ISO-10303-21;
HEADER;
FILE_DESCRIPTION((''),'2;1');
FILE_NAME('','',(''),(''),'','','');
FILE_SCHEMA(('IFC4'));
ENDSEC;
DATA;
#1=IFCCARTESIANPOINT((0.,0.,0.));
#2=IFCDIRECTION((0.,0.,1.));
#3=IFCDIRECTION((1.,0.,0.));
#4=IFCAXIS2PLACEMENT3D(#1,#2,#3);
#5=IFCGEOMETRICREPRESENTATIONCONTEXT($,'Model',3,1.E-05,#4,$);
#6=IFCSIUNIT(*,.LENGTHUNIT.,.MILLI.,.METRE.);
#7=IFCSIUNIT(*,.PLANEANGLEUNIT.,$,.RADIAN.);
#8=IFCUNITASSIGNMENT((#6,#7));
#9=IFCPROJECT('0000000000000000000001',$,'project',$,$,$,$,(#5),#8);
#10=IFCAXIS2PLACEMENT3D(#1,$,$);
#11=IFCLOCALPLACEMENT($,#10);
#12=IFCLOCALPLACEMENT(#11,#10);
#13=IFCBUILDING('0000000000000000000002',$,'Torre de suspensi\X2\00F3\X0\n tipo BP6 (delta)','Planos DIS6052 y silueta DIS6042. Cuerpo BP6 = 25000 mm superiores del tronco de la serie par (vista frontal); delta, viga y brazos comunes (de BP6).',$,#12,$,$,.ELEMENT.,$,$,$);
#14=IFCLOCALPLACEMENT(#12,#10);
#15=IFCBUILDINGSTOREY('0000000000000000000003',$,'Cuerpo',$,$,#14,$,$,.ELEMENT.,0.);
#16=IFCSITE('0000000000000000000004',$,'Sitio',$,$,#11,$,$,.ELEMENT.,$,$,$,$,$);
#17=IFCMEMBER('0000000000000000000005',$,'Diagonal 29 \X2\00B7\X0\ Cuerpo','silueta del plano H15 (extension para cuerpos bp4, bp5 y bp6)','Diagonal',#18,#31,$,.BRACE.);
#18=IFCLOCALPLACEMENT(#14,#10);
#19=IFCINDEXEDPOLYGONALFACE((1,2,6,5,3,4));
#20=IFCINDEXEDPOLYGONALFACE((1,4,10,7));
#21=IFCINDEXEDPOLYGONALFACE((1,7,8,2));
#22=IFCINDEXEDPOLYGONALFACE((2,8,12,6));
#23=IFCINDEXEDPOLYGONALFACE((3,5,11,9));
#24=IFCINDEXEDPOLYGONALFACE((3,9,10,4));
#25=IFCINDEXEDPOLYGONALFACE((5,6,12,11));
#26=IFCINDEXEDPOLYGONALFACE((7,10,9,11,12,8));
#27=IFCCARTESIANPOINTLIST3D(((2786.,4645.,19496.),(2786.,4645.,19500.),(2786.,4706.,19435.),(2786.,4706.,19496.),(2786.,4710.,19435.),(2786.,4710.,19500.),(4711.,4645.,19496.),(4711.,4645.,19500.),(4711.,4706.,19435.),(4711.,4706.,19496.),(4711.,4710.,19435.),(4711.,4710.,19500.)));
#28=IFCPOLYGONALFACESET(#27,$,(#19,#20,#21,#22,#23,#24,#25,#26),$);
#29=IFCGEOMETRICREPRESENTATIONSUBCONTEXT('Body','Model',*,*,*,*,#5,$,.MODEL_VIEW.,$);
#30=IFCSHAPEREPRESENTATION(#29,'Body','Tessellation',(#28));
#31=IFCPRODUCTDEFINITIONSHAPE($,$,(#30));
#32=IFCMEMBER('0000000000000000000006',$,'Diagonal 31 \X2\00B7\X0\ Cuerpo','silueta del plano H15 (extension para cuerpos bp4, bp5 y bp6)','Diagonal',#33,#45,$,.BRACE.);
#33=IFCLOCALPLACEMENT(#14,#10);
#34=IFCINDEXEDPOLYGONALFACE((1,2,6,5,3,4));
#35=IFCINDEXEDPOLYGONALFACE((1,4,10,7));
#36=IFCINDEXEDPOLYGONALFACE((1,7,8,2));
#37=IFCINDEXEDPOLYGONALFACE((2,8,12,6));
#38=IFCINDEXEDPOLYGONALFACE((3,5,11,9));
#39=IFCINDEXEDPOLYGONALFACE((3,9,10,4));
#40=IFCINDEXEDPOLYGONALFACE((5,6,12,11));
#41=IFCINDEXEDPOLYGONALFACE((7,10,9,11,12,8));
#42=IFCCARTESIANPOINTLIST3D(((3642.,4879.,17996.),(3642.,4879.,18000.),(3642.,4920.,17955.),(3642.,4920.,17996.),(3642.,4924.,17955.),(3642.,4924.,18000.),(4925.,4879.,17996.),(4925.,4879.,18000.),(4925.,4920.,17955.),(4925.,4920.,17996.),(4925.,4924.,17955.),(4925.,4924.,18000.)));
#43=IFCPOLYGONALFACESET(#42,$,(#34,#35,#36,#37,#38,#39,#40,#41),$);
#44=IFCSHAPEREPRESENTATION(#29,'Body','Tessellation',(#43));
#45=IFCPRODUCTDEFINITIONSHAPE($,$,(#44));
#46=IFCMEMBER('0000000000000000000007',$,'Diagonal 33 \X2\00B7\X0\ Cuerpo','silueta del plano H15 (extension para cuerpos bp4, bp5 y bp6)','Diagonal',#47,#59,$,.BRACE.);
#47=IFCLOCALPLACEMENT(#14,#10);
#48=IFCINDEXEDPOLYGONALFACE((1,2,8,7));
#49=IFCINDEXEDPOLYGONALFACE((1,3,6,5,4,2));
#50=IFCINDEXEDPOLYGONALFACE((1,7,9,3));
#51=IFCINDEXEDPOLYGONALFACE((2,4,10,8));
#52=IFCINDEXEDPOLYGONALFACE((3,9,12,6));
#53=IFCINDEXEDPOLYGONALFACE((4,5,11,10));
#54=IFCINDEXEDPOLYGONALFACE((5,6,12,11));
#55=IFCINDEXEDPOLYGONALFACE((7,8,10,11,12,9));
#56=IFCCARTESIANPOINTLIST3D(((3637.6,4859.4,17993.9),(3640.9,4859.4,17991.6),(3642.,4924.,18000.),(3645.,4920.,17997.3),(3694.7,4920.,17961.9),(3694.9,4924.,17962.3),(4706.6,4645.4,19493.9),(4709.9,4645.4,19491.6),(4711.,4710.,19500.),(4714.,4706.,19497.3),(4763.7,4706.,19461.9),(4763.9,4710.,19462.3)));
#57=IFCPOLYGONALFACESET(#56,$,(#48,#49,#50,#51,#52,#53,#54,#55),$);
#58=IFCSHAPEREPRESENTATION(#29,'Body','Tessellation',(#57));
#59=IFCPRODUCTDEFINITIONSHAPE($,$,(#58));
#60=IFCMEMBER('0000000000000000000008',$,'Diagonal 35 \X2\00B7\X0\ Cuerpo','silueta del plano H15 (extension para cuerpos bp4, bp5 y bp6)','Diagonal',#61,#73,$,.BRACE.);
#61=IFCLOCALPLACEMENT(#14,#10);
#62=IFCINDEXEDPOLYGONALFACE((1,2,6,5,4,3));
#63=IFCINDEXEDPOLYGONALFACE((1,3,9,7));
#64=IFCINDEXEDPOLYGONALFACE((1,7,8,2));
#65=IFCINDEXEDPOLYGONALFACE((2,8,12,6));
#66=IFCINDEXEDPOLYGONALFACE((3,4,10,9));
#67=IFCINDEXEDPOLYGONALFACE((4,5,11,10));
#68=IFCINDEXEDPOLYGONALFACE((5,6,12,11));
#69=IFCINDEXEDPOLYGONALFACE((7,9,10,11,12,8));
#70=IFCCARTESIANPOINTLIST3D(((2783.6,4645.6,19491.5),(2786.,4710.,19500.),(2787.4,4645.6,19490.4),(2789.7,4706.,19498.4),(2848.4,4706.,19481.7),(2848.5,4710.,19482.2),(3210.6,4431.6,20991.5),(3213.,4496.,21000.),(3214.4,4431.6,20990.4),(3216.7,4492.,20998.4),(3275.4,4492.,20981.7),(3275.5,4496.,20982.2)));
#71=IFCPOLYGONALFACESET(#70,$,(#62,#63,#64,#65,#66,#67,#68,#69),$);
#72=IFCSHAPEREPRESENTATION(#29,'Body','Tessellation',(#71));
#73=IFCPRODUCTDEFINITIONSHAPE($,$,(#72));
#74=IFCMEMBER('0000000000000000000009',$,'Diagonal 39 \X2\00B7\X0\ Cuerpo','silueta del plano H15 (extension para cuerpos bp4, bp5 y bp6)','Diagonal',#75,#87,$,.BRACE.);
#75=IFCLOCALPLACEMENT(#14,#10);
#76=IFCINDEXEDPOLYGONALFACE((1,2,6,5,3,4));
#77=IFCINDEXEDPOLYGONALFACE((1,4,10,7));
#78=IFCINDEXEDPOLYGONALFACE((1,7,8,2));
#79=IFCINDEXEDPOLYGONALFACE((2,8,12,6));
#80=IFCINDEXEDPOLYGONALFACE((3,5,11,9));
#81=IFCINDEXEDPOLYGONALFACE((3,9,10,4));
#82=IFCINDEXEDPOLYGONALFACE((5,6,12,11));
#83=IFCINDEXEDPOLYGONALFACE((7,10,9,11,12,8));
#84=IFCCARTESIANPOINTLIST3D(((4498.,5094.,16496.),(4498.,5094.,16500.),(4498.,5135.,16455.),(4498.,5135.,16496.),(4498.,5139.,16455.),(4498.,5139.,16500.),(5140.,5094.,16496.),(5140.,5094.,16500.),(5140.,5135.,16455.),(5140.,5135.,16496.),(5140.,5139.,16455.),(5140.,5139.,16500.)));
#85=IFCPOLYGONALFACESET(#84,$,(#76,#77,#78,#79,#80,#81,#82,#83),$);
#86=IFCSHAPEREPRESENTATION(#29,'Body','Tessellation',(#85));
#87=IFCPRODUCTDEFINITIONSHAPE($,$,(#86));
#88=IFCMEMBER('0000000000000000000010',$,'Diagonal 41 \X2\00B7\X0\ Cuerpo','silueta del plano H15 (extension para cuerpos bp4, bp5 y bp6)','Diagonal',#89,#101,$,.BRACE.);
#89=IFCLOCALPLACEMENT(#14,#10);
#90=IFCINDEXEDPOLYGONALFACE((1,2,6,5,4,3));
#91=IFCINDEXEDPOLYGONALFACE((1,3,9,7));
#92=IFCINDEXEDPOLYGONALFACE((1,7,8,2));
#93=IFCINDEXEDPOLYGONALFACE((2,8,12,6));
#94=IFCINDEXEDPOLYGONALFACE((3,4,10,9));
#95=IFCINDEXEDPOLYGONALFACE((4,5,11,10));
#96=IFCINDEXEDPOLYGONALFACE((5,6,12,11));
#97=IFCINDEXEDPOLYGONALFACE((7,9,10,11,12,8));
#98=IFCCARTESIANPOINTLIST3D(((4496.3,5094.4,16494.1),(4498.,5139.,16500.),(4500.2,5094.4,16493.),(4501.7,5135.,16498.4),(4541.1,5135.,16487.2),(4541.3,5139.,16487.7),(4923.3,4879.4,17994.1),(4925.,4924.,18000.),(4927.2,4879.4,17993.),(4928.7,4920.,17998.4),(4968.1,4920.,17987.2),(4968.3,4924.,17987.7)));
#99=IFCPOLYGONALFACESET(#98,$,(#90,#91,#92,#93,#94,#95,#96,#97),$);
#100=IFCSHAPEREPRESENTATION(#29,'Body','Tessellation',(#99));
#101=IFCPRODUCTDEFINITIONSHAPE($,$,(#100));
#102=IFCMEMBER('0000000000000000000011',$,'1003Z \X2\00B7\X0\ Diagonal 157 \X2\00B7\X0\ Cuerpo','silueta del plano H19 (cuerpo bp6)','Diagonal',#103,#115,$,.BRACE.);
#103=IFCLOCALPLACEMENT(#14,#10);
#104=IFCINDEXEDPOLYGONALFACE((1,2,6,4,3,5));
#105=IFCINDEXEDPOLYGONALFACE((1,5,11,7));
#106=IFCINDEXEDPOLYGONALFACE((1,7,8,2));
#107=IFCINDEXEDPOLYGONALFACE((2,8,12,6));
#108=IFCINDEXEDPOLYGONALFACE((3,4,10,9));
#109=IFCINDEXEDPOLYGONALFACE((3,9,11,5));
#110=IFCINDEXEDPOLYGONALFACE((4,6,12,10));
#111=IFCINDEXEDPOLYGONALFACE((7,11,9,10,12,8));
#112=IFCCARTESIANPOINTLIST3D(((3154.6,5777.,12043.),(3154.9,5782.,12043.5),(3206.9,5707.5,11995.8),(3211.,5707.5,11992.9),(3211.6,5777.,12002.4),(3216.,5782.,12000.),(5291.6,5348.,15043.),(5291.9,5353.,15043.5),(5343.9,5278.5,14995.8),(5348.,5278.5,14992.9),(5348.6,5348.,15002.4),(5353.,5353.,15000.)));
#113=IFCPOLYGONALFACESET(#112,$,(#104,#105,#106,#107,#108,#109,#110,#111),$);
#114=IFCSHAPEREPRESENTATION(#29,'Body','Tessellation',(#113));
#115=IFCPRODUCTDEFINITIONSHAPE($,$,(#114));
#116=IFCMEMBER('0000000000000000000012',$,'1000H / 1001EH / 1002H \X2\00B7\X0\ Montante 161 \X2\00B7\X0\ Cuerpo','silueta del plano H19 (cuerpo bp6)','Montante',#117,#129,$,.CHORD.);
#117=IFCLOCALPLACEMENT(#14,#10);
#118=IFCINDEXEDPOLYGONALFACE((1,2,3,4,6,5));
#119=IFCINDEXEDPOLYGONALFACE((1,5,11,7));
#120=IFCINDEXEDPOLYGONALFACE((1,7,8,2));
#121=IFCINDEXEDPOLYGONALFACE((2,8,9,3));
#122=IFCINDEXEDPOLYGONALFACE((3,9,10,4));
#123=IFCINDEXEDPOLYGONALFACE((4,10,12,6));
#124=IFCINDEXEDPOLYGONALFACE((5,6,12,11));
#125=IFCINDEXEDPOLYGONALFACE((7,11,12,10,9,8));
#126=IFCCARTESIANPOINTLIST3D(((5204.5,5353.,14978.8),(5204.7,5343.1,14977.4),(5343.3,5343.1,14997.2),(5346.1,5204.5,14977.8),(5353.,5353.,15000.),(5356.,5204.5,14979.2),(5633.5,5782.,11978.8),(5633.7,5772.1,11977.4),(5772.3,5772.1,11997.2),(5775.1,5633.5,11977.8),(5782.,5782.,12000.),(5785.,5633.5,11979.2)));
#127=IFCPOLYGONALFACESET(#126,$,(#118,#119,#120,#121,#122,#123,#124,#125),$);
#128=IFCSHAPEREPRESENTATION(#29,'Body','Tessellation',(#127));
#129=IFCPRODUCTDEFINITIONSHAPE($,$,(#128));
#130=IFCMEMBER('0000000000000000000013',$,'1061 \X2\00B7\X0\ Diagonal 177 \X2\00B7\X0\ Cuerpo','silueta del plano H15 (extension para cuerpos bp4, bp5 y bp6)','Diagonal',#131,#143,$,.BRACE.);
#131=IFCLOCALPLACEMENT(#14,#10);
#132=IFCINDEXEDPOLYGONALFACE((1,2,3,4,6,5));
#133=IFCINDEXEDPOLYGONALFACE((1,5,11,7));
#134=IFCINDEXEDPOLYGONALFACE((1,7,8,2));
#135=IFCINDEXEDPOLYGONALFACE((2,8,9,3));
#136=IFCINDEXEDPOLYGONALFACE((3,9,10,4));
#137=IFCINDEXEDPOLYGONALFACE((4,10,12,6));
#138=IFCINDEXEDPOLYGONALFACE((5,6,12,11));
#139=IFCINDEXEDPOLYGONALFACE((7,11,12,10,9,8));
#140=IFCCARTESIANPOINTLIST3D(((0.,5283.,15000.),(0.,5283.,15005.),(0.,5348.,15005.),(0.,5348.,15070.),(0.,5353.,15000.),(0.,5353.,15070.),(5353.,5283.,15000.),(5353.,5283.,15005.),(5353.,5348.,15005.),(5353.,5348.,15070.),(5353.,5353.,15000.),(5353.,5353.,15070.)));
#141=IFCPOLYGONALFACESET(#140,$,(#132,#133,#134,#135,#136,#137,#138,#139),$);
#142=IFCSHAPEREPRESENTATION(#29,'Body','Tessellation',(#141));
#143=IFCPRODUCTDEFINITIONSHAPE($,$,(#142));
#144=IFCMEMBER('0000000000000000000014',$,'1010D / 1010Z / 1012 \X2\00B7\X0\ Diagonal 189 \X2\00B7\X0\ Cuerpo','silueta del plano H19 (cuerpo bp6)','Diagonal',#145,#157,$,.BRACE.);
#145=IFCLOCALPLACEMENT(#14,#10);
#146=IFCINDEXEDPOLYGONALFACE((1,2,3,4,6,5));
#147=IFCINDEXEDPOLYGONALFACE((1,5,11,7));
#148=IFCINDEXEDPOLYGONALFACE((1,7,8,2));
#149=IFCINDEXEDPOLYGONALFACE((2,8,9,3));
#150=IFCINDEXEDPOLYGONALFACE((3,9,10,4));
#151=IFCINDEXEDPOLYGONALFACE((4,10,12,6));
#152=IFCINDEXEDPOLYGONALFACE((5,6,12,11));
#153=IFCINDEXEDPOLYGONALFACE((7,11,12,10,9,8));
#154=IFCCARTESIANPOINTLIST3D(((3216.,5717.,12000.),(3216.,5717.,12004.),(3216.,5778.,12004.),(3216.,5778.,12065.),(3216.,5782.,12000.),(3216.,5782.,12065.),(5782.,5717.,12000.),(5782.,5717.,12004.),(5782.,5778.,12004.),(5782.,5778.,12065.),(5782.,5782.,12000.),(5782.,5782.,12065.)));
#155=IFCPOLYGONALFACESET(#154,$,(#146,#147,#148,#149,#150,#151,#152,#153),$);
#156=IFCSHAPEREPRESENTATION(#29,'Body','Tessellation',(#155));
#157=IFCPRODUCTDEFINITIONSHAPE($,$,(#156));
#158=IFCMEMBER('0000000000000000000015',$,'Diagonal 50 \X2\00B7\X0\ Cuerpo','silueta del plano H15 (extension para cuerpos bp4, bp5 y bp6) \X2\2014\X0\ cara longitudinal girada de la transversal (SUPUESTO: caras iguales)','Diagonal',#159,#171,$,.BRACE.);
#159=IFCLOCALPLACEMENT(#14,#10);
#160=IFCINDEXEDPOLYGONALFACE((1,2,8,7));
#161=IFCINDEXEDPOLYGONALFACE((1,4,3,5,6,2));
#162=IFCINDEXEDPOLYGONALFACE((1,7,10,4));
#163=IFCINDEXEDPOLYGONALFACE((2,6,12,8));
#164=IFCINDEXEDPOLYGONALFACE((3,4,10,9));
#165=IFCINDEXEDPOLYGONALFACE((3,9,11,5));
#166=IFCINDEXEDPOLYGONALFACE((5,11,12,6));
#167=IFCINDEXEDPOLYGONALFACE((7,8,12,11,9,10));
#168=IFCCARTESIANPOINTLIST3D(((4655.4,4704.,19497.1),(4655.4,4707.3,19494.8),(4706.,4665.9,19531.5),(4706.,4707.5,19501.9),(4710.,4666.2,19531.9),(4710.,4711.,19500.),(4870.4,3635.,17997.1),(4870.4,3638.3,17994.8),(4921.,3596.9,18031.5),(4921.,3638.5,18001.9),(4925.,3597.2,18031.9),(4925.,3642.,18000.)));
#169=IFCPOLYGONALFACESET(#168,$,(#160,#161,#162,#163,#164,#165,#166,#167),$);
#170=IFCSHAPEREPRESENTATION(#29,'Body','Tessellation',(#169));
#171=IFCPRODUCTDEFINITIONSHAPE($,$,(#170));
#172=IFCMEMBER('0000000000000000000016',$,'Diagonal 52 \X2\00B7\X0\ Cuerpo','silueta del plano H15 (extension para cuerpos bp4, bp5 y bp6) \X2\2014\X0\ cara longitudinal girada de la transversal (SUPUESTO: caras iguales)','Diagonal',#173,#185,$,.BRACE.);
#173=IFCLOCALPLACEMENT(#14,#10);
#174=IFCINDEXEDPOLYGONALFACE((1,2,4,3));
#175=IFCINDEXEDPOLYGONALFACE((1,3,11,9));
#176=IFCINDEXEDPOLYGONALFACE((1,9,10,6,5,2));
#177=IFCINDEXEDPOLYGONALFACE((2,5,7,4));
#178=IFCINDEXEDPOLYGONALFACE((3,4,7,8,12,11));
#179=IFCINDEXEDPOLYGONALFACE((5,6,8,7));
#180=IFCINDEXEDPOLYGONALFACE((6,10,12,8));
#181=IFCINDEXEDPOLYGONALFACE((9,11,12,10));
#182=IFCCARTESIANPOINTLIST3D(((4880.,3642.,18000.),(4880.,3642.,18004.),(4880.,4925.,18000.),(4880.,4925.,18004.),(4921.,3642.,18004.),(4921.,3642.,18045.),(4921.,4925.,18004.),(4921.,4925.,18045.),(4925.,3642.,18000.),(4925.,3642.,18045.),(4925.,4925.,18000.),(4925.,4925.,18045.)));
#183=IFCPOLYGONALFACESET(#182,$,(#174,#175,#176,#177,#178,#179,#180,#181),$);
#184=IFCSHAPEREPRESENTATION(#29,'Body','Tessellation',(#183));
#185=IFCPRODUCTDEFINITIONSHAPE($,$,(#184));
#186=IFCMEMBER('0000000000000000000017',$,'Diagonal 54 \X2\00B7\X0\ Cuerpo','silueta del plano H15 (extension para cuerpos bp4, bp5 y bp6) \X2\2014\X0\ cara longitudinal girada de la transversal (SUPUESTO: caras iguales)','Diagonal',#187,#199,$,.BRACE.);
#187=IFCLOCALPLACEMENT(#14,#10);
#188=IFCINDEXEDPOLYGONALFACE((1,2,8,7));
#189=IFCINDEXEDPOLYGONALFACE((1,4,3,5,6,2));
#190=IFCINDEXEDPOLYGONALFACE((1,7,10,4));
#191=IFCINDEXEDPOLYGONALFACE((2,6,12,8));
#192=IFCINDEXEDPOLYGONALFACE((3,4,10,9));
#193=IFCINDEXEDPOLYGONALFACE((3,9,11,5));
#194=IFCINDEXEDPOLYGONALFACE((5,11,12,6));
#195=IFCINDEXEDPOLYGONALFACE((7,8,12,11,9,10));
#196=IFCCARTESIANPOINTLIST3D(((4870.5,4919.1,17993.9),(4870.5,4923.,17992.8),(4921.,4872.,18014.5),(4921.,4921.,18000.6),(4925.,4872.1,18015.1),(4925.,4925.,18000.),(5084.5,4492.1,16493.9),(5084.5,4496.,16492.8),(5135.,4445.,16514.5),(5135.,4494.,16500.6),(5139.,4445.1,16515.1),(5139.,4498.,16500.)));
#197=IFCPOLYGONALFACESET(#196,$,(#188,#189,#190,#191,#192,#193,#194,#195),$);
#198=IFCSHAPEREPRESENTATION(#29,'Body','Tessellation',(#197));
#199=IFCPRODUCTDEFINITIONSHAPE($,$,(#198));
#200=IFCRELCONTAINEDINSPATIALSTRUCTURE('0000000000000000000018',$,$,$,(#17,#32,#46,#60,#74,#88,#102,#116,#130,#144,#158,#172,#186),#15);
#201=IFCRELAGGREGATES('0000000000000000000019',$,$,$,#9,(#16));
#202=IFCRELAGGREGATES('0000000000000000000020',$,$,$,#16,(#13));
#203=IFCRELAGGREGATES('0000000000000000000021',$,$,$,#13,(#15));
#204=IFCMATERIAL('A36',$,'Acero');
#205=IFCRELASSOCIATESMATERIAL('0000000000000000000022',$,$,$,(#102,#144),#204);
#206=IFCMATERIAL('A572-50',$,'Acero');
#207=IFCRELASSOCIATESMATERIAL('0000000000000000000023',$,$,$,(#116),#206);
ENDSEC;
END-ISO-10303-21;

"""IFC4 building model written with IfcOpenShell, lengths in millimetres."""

from ifc_helpers import new_model, si_unit, frame, frame_2d, origin, origin_with_axes, place, context, subcontext, project, spatial, l_section, extrude, material, element, save


model = new_model("IFC4")

# Units and contexts
model_context = context("Model", 3, precision=1e-05, world=origin_with_axes())
body_context = subcontext(model_context, "Body", "Model", "MODEL_VIEW")
ifc_project = project(units=[si_unit("LENGTHUNIT", "METRE", prefix="MILLI"), si_unit("PLANEANGLEUNIT", "RADIAN")], contexts=[model_context])

# Site, building, storey
site_placement = place(None, origin())
site = spatial("IfcSite", under=ifc_project, at=site_placement, Name="Sitio", CompositionType="ELEMENT")
building_placement = place(site_placement, origin())
building = spatial("IfcBuilding", under=site, at=building_placement, Name="Torre de suspensión tipo BP6 (delta)", Description="Planos DIS6052 y silueta DIS6042. Cuerpo BP6 = 25000 mm superiores del tronco de la serie par (vista frontal); delta, viga y brazos comunes (de BP6).", CompositionType="ELEMENT")
storey_placement = place(building_placement, origin())
storey = spatial("IfcBuildingStorey", under=building, at=storey_placement, Name="Cuerpo", CompositionType="ELEMENT", Elevation=0.0)

# Members
member_1_placement = place(storey_placement, frame((2786.0, 4710.0, 19500.0), z_axis=(1.0, 0.0, 0.0), x_axis=(0.0, -1.0, 0.0)))
element("IfcMember", 1, at=member_1_placement, inside=storey, Name="Diagonal 29 · Cuerpo", Description="silueta del plano H15 (extension para cuerpos bp4, bp5 y bp6)", ObjectType="Diagonal", PredefinedType="BRACE", context=body_context, shape_type="SweptSolid", body=[
    extrude(l_section(Depth=65.0, Width=65.0, Thickness=4.0, at=frame_2d((32.5, 32.5))), None, (0.0, 0.0, 1.0), 1925.0),
])
member_2_placement = place(storey_placement, frame((3642.0, 4924.0, 18000.0), z_axis=(1.0, 0.0, 0.0), x_axis=(0.0, -1.0, 0.0)))
element("IfcMember", 2, at=member_2_placement, inside=storey, Name="Diagonal 31 · Cuerpo", Description="silueta del plano H15 (extension para cuerpos bp4, bp5 y bp6)", ObjectType="Diagonal", PredefinedType="BRACE", context=body_context, shape_type="SweptSolid", body=[
    extrude(l_section(Depth=45.0, Width=45.0, Thickness=4.0, at=frame_2d((22.5, 22.5))), None, (0.0, 0.0, 1.0), 1283.0),
])
member_3_placement = place(storey_placement, frame((3642.0, 4924.0, 18000.0), z_axis=(0.576487, -0.115405, 0.808915), x_axis=(-0.066977, -0.993318, -0.093981)))
element("IfcMember", 3, at=member_3_placement, inside=storey, Name="Diagonal 33 · Cuerpo", Description="silueta del plano H15 (extension para cuerpos bp4, bp5 y bp6)", ObjectType="Diagonal", PredefinedType="BRACE", context=body_context, shape_type="SweptSolid", body=[
    extrude(l_section(Depth=65.0, Width=65.0, Thickness=4.0, at=frame_2d((32.5, 32.5))), None, (0.0, 0.0, 1.0), 1854.3),
])
member_4_placement = place(storey_placement, frame((2786.0, 4710.0, 19500.0), z_axis=(0.271248, -0.135942, 0.952861), x_axis=(-0.037219, -0.990717, -0.130747)))
element("IfcMember", 4, at=member_4_placement, inside=storey, Name="Diagonal 35 · Cuerpo", Description="silueta del plano H15 (extension para cuerpos bp4, bp5 y bp6)", ObjectType="Diagonal", PredefinedType="BRACE", context=body_context, shape_type="SweptSolid", body=[
    extrude(l_section(Depth=65.0, Width=65.0, Thickness=4.0, at=frame_2d((32.5, 32.5))), None, (0.0, 0.0, 1.0), 1574.2),
])
member_5_placement = place(storey_placement, frame((4498.0, 5139.0, 16500.0), z_axis=(1.0, 0.0, 0.0), x_axis=(0.0, -1.0, 0.0)))
element("IfcMember", 5, at=member_5_placement, inside=storey, Name="Diagonal 39 · Cuerpo", Description="silueta del plano H15 (extension para cuerpos bp4, bp5 y bp6)", ObjectType="Diagonal", PredefinedType="BRACE", context=body_context, shape_type="SweptSolid", body=[
    extrude(l_section(Depth=45.0, Width=45.0, Thickness=4.0, at=frame_2d((22.5, 22.5))), None, (0.0, 0.0, 1.0), 642.0),
])
member_6_placement = place(storey_placement, frame((4498.0, 5139.0, 16500.0), z_axis=(0.271224, -0.136565, 0.952779), x_axis=(-0.03739, -0.990631, -0.131347)))
element("IfcMember", 6, at=member_6_placement, inside=storey, Name="Diagonal 41 · Cuerpo", Description="silueta del plano H15 (extension para cuerpos bp4, bp5 y bp6)", ObjectType="Diagonal", PredefinedType="BRACE", context=body_context, shape_type="SweptSolid", body=[
    extrude(l_section(Depth=45.0, Width=45.0, Thickness=4.0, at=frame_2d((22.5, 22.5))), None, (0.0, 0.0, 1.0), 1574.3),
])
ifc_material_1 = material(Name="A36", Category="Acero")
member_7_placement = place(storey_placement, frame((5353.0, 5353.0, 15000.0), z_axis=(-0.576289, 0.115689, -0.809016), x_axis=(-0.067121, -0.993285, -0.094227)))
element("IfcMember", 7, at=member_7_placement, inside=storey, material=ifc_material_1, Name="1003Z · Diagonal 157 · Cuerpo", Description="silueta del plano H19 (cuerpo bp6)", ObjectType="Diagonal", PredefinedType="BRACE", context=body_context, shape_type="SweptSolid", body=[
    extrude(l_section(Depth=75.0, Width=75.0, Thickness=5.0, at=frame_2d((37.5, 37.5))), None, (0.0, 0.0, 1.0), 3708.2),
])
ifc_material_2 = material(Name="A572-50", Category="Acero")
member_8_placement = place(storey_placement, frame((5353.0, 5353.0, 15000.0), z_axis=(0.140163, 0.140163, -0.980158), x_axis=(0.019841, -0.990129, -0.138751)))
element("IfcMember", 8, at=member_8_placement, inside=storey, material=ifc_material_2, Name="1000H / 1001EH / 1002H · Montante 161 · Cuerpo", Description="silueta del plano H19 (cuerpo bp6)", ObjectType="Montante", PredefinedType="CHORD", context=body_context, shape_type="SweptSolid", body=[
    extrude(l_section(Depth=150.0, Width=150.0, Thickness=10.0, at=frame_2d((75.0, 75.0))), None, (0.0, 0.0, 1.0), 3060.7),
])
member_9_placement = place(storey_placement, frame((5353.0, 5353.0, 15000.0), z_axis=(-1.0, 0.0, 0.0), x_axis=(0.0, -1.0, 0.0)))
element("IfcMember", 9, at=member_9_placement, inside=storey, Name="1061 · Diagonal 177 · Cuerpo", Description="silueta del plano H15 (extension para cuerpos bp4, bp5 y bp6)", ObjectType="Diagonal", PredefinedType="BRACE", context=body_context, shape_type="SweptSolid", body=[
    extrude(l_section(Depth=70.0, Width=70.0, Thickness=5.0, at=frame_2d((35.0, 35.0))), None, (0.0, 0.0, 1.0), 5353.0),
])
member_10_placement = place(storey_placement, frame((5782.0, 5782.0, 12000.0), z_axis=(-1.0, 0.0, 0.0), x_axis=(0.0, -1.0, 0.0)))
element("IfcMember", 10, at=member_10_placement, inside=storey, material=ifc_material_1, Name="1010D / 1010Z / 1012 · Diagonal 189 · Cuerpo", Description="silueta del plano H19 (cuerpo bp6)", ObjectType="Diagonal", PredefinedType="BRACE", context=body_context, shape_type="SweptSolid", body=[
    extrude(l_section(Depth=65.0, Width=65.0, Thickness=4.0, at=frame_2d((32.5, 32.5))), None, (0.0, 0.0, 1.0), 2566.0),
])
member_11_placement = place(storey_placement, frame((4925.0, 3642.0, 18000.0), z_axis=(-0.115937, 0.576451, 0.808865), x_axis=(-0.993257, -0.067286, -0.094414)))
element("IfcMember", 11, at=member_11_placement, inside=storey, Name="Diagonal 50 · Cuerpo", Description="silueta del plano H15 (extension para cuerpos bp4, bp5 y bp6) — cara longitudinal girada de la transversal (SUPUESTO: caras iguales)", ObjectType="Diagonal", PredefinedType="BRACE", context=body_context, shape_type="SweptSolid", body=[
    extrude(l_section(Depth=55.0, Width=55.0, Thickness=4.0, at=frame_2d((27.5, 27.5))), None, (0.0, 0.0, 1.0), 1854.5),
])
member_12_placement = place(storey_placement, frame((4925.0, 3642.0, 18000.0), z_axis=(0.0, 1.0, 0.0), x_axis=(-1.0, 0.0, 0.0)))
element("IfcMember", 12, at=member_12_placement, inside=storey, Name="Diagonal 52 · Cuerpo", Description="silueta del plano H15 (extension para cuerpos bp4, bp5 y bp6) — cara longitudinal girada de la transversal (SUPUESTO: caras iguales)", ObjectType="Diagonal", PredefinedType="BRACE", context=body_context, shape_type="SweptSolid", body=[
    extrude(l_section(Depth=45.0, Width=45.0, Thickness=4.0, at=frame_2d((22.5, 22.5))), None, (0.0, 0.0, 1.0), 1283.0),
])
member_13_placement = place(storey_placement, frame((5139.0, 4498.0, 16500.0), z_axis=(-0.135942, 0.271248, 0.952861), x_axis=(-0.990717, -0.037219, -0.130747)))
element("IfcMember", 13, at=member_13_placement, inside=storey, Name="Diagonal 54 · Cuerpo", Description="silueta del plano H15 (extension para cuerpos bp4, bp5 y bp6) — cara longitudinal girada de la transversal (SUPUESTO: caras iguales)", ObjectType="Diagonal", PredefinedType="BRACE", context=body_context, shape_type="SweptSolid", body=[
    extrude(l_section(Depth=55.0, Width=55.0, Thickness=4.0, at=frame_2d((27.5, 27.5))), None, (0.0, 0.0, 1.0), 1574.2),
])

save(model, "model.ifc")
